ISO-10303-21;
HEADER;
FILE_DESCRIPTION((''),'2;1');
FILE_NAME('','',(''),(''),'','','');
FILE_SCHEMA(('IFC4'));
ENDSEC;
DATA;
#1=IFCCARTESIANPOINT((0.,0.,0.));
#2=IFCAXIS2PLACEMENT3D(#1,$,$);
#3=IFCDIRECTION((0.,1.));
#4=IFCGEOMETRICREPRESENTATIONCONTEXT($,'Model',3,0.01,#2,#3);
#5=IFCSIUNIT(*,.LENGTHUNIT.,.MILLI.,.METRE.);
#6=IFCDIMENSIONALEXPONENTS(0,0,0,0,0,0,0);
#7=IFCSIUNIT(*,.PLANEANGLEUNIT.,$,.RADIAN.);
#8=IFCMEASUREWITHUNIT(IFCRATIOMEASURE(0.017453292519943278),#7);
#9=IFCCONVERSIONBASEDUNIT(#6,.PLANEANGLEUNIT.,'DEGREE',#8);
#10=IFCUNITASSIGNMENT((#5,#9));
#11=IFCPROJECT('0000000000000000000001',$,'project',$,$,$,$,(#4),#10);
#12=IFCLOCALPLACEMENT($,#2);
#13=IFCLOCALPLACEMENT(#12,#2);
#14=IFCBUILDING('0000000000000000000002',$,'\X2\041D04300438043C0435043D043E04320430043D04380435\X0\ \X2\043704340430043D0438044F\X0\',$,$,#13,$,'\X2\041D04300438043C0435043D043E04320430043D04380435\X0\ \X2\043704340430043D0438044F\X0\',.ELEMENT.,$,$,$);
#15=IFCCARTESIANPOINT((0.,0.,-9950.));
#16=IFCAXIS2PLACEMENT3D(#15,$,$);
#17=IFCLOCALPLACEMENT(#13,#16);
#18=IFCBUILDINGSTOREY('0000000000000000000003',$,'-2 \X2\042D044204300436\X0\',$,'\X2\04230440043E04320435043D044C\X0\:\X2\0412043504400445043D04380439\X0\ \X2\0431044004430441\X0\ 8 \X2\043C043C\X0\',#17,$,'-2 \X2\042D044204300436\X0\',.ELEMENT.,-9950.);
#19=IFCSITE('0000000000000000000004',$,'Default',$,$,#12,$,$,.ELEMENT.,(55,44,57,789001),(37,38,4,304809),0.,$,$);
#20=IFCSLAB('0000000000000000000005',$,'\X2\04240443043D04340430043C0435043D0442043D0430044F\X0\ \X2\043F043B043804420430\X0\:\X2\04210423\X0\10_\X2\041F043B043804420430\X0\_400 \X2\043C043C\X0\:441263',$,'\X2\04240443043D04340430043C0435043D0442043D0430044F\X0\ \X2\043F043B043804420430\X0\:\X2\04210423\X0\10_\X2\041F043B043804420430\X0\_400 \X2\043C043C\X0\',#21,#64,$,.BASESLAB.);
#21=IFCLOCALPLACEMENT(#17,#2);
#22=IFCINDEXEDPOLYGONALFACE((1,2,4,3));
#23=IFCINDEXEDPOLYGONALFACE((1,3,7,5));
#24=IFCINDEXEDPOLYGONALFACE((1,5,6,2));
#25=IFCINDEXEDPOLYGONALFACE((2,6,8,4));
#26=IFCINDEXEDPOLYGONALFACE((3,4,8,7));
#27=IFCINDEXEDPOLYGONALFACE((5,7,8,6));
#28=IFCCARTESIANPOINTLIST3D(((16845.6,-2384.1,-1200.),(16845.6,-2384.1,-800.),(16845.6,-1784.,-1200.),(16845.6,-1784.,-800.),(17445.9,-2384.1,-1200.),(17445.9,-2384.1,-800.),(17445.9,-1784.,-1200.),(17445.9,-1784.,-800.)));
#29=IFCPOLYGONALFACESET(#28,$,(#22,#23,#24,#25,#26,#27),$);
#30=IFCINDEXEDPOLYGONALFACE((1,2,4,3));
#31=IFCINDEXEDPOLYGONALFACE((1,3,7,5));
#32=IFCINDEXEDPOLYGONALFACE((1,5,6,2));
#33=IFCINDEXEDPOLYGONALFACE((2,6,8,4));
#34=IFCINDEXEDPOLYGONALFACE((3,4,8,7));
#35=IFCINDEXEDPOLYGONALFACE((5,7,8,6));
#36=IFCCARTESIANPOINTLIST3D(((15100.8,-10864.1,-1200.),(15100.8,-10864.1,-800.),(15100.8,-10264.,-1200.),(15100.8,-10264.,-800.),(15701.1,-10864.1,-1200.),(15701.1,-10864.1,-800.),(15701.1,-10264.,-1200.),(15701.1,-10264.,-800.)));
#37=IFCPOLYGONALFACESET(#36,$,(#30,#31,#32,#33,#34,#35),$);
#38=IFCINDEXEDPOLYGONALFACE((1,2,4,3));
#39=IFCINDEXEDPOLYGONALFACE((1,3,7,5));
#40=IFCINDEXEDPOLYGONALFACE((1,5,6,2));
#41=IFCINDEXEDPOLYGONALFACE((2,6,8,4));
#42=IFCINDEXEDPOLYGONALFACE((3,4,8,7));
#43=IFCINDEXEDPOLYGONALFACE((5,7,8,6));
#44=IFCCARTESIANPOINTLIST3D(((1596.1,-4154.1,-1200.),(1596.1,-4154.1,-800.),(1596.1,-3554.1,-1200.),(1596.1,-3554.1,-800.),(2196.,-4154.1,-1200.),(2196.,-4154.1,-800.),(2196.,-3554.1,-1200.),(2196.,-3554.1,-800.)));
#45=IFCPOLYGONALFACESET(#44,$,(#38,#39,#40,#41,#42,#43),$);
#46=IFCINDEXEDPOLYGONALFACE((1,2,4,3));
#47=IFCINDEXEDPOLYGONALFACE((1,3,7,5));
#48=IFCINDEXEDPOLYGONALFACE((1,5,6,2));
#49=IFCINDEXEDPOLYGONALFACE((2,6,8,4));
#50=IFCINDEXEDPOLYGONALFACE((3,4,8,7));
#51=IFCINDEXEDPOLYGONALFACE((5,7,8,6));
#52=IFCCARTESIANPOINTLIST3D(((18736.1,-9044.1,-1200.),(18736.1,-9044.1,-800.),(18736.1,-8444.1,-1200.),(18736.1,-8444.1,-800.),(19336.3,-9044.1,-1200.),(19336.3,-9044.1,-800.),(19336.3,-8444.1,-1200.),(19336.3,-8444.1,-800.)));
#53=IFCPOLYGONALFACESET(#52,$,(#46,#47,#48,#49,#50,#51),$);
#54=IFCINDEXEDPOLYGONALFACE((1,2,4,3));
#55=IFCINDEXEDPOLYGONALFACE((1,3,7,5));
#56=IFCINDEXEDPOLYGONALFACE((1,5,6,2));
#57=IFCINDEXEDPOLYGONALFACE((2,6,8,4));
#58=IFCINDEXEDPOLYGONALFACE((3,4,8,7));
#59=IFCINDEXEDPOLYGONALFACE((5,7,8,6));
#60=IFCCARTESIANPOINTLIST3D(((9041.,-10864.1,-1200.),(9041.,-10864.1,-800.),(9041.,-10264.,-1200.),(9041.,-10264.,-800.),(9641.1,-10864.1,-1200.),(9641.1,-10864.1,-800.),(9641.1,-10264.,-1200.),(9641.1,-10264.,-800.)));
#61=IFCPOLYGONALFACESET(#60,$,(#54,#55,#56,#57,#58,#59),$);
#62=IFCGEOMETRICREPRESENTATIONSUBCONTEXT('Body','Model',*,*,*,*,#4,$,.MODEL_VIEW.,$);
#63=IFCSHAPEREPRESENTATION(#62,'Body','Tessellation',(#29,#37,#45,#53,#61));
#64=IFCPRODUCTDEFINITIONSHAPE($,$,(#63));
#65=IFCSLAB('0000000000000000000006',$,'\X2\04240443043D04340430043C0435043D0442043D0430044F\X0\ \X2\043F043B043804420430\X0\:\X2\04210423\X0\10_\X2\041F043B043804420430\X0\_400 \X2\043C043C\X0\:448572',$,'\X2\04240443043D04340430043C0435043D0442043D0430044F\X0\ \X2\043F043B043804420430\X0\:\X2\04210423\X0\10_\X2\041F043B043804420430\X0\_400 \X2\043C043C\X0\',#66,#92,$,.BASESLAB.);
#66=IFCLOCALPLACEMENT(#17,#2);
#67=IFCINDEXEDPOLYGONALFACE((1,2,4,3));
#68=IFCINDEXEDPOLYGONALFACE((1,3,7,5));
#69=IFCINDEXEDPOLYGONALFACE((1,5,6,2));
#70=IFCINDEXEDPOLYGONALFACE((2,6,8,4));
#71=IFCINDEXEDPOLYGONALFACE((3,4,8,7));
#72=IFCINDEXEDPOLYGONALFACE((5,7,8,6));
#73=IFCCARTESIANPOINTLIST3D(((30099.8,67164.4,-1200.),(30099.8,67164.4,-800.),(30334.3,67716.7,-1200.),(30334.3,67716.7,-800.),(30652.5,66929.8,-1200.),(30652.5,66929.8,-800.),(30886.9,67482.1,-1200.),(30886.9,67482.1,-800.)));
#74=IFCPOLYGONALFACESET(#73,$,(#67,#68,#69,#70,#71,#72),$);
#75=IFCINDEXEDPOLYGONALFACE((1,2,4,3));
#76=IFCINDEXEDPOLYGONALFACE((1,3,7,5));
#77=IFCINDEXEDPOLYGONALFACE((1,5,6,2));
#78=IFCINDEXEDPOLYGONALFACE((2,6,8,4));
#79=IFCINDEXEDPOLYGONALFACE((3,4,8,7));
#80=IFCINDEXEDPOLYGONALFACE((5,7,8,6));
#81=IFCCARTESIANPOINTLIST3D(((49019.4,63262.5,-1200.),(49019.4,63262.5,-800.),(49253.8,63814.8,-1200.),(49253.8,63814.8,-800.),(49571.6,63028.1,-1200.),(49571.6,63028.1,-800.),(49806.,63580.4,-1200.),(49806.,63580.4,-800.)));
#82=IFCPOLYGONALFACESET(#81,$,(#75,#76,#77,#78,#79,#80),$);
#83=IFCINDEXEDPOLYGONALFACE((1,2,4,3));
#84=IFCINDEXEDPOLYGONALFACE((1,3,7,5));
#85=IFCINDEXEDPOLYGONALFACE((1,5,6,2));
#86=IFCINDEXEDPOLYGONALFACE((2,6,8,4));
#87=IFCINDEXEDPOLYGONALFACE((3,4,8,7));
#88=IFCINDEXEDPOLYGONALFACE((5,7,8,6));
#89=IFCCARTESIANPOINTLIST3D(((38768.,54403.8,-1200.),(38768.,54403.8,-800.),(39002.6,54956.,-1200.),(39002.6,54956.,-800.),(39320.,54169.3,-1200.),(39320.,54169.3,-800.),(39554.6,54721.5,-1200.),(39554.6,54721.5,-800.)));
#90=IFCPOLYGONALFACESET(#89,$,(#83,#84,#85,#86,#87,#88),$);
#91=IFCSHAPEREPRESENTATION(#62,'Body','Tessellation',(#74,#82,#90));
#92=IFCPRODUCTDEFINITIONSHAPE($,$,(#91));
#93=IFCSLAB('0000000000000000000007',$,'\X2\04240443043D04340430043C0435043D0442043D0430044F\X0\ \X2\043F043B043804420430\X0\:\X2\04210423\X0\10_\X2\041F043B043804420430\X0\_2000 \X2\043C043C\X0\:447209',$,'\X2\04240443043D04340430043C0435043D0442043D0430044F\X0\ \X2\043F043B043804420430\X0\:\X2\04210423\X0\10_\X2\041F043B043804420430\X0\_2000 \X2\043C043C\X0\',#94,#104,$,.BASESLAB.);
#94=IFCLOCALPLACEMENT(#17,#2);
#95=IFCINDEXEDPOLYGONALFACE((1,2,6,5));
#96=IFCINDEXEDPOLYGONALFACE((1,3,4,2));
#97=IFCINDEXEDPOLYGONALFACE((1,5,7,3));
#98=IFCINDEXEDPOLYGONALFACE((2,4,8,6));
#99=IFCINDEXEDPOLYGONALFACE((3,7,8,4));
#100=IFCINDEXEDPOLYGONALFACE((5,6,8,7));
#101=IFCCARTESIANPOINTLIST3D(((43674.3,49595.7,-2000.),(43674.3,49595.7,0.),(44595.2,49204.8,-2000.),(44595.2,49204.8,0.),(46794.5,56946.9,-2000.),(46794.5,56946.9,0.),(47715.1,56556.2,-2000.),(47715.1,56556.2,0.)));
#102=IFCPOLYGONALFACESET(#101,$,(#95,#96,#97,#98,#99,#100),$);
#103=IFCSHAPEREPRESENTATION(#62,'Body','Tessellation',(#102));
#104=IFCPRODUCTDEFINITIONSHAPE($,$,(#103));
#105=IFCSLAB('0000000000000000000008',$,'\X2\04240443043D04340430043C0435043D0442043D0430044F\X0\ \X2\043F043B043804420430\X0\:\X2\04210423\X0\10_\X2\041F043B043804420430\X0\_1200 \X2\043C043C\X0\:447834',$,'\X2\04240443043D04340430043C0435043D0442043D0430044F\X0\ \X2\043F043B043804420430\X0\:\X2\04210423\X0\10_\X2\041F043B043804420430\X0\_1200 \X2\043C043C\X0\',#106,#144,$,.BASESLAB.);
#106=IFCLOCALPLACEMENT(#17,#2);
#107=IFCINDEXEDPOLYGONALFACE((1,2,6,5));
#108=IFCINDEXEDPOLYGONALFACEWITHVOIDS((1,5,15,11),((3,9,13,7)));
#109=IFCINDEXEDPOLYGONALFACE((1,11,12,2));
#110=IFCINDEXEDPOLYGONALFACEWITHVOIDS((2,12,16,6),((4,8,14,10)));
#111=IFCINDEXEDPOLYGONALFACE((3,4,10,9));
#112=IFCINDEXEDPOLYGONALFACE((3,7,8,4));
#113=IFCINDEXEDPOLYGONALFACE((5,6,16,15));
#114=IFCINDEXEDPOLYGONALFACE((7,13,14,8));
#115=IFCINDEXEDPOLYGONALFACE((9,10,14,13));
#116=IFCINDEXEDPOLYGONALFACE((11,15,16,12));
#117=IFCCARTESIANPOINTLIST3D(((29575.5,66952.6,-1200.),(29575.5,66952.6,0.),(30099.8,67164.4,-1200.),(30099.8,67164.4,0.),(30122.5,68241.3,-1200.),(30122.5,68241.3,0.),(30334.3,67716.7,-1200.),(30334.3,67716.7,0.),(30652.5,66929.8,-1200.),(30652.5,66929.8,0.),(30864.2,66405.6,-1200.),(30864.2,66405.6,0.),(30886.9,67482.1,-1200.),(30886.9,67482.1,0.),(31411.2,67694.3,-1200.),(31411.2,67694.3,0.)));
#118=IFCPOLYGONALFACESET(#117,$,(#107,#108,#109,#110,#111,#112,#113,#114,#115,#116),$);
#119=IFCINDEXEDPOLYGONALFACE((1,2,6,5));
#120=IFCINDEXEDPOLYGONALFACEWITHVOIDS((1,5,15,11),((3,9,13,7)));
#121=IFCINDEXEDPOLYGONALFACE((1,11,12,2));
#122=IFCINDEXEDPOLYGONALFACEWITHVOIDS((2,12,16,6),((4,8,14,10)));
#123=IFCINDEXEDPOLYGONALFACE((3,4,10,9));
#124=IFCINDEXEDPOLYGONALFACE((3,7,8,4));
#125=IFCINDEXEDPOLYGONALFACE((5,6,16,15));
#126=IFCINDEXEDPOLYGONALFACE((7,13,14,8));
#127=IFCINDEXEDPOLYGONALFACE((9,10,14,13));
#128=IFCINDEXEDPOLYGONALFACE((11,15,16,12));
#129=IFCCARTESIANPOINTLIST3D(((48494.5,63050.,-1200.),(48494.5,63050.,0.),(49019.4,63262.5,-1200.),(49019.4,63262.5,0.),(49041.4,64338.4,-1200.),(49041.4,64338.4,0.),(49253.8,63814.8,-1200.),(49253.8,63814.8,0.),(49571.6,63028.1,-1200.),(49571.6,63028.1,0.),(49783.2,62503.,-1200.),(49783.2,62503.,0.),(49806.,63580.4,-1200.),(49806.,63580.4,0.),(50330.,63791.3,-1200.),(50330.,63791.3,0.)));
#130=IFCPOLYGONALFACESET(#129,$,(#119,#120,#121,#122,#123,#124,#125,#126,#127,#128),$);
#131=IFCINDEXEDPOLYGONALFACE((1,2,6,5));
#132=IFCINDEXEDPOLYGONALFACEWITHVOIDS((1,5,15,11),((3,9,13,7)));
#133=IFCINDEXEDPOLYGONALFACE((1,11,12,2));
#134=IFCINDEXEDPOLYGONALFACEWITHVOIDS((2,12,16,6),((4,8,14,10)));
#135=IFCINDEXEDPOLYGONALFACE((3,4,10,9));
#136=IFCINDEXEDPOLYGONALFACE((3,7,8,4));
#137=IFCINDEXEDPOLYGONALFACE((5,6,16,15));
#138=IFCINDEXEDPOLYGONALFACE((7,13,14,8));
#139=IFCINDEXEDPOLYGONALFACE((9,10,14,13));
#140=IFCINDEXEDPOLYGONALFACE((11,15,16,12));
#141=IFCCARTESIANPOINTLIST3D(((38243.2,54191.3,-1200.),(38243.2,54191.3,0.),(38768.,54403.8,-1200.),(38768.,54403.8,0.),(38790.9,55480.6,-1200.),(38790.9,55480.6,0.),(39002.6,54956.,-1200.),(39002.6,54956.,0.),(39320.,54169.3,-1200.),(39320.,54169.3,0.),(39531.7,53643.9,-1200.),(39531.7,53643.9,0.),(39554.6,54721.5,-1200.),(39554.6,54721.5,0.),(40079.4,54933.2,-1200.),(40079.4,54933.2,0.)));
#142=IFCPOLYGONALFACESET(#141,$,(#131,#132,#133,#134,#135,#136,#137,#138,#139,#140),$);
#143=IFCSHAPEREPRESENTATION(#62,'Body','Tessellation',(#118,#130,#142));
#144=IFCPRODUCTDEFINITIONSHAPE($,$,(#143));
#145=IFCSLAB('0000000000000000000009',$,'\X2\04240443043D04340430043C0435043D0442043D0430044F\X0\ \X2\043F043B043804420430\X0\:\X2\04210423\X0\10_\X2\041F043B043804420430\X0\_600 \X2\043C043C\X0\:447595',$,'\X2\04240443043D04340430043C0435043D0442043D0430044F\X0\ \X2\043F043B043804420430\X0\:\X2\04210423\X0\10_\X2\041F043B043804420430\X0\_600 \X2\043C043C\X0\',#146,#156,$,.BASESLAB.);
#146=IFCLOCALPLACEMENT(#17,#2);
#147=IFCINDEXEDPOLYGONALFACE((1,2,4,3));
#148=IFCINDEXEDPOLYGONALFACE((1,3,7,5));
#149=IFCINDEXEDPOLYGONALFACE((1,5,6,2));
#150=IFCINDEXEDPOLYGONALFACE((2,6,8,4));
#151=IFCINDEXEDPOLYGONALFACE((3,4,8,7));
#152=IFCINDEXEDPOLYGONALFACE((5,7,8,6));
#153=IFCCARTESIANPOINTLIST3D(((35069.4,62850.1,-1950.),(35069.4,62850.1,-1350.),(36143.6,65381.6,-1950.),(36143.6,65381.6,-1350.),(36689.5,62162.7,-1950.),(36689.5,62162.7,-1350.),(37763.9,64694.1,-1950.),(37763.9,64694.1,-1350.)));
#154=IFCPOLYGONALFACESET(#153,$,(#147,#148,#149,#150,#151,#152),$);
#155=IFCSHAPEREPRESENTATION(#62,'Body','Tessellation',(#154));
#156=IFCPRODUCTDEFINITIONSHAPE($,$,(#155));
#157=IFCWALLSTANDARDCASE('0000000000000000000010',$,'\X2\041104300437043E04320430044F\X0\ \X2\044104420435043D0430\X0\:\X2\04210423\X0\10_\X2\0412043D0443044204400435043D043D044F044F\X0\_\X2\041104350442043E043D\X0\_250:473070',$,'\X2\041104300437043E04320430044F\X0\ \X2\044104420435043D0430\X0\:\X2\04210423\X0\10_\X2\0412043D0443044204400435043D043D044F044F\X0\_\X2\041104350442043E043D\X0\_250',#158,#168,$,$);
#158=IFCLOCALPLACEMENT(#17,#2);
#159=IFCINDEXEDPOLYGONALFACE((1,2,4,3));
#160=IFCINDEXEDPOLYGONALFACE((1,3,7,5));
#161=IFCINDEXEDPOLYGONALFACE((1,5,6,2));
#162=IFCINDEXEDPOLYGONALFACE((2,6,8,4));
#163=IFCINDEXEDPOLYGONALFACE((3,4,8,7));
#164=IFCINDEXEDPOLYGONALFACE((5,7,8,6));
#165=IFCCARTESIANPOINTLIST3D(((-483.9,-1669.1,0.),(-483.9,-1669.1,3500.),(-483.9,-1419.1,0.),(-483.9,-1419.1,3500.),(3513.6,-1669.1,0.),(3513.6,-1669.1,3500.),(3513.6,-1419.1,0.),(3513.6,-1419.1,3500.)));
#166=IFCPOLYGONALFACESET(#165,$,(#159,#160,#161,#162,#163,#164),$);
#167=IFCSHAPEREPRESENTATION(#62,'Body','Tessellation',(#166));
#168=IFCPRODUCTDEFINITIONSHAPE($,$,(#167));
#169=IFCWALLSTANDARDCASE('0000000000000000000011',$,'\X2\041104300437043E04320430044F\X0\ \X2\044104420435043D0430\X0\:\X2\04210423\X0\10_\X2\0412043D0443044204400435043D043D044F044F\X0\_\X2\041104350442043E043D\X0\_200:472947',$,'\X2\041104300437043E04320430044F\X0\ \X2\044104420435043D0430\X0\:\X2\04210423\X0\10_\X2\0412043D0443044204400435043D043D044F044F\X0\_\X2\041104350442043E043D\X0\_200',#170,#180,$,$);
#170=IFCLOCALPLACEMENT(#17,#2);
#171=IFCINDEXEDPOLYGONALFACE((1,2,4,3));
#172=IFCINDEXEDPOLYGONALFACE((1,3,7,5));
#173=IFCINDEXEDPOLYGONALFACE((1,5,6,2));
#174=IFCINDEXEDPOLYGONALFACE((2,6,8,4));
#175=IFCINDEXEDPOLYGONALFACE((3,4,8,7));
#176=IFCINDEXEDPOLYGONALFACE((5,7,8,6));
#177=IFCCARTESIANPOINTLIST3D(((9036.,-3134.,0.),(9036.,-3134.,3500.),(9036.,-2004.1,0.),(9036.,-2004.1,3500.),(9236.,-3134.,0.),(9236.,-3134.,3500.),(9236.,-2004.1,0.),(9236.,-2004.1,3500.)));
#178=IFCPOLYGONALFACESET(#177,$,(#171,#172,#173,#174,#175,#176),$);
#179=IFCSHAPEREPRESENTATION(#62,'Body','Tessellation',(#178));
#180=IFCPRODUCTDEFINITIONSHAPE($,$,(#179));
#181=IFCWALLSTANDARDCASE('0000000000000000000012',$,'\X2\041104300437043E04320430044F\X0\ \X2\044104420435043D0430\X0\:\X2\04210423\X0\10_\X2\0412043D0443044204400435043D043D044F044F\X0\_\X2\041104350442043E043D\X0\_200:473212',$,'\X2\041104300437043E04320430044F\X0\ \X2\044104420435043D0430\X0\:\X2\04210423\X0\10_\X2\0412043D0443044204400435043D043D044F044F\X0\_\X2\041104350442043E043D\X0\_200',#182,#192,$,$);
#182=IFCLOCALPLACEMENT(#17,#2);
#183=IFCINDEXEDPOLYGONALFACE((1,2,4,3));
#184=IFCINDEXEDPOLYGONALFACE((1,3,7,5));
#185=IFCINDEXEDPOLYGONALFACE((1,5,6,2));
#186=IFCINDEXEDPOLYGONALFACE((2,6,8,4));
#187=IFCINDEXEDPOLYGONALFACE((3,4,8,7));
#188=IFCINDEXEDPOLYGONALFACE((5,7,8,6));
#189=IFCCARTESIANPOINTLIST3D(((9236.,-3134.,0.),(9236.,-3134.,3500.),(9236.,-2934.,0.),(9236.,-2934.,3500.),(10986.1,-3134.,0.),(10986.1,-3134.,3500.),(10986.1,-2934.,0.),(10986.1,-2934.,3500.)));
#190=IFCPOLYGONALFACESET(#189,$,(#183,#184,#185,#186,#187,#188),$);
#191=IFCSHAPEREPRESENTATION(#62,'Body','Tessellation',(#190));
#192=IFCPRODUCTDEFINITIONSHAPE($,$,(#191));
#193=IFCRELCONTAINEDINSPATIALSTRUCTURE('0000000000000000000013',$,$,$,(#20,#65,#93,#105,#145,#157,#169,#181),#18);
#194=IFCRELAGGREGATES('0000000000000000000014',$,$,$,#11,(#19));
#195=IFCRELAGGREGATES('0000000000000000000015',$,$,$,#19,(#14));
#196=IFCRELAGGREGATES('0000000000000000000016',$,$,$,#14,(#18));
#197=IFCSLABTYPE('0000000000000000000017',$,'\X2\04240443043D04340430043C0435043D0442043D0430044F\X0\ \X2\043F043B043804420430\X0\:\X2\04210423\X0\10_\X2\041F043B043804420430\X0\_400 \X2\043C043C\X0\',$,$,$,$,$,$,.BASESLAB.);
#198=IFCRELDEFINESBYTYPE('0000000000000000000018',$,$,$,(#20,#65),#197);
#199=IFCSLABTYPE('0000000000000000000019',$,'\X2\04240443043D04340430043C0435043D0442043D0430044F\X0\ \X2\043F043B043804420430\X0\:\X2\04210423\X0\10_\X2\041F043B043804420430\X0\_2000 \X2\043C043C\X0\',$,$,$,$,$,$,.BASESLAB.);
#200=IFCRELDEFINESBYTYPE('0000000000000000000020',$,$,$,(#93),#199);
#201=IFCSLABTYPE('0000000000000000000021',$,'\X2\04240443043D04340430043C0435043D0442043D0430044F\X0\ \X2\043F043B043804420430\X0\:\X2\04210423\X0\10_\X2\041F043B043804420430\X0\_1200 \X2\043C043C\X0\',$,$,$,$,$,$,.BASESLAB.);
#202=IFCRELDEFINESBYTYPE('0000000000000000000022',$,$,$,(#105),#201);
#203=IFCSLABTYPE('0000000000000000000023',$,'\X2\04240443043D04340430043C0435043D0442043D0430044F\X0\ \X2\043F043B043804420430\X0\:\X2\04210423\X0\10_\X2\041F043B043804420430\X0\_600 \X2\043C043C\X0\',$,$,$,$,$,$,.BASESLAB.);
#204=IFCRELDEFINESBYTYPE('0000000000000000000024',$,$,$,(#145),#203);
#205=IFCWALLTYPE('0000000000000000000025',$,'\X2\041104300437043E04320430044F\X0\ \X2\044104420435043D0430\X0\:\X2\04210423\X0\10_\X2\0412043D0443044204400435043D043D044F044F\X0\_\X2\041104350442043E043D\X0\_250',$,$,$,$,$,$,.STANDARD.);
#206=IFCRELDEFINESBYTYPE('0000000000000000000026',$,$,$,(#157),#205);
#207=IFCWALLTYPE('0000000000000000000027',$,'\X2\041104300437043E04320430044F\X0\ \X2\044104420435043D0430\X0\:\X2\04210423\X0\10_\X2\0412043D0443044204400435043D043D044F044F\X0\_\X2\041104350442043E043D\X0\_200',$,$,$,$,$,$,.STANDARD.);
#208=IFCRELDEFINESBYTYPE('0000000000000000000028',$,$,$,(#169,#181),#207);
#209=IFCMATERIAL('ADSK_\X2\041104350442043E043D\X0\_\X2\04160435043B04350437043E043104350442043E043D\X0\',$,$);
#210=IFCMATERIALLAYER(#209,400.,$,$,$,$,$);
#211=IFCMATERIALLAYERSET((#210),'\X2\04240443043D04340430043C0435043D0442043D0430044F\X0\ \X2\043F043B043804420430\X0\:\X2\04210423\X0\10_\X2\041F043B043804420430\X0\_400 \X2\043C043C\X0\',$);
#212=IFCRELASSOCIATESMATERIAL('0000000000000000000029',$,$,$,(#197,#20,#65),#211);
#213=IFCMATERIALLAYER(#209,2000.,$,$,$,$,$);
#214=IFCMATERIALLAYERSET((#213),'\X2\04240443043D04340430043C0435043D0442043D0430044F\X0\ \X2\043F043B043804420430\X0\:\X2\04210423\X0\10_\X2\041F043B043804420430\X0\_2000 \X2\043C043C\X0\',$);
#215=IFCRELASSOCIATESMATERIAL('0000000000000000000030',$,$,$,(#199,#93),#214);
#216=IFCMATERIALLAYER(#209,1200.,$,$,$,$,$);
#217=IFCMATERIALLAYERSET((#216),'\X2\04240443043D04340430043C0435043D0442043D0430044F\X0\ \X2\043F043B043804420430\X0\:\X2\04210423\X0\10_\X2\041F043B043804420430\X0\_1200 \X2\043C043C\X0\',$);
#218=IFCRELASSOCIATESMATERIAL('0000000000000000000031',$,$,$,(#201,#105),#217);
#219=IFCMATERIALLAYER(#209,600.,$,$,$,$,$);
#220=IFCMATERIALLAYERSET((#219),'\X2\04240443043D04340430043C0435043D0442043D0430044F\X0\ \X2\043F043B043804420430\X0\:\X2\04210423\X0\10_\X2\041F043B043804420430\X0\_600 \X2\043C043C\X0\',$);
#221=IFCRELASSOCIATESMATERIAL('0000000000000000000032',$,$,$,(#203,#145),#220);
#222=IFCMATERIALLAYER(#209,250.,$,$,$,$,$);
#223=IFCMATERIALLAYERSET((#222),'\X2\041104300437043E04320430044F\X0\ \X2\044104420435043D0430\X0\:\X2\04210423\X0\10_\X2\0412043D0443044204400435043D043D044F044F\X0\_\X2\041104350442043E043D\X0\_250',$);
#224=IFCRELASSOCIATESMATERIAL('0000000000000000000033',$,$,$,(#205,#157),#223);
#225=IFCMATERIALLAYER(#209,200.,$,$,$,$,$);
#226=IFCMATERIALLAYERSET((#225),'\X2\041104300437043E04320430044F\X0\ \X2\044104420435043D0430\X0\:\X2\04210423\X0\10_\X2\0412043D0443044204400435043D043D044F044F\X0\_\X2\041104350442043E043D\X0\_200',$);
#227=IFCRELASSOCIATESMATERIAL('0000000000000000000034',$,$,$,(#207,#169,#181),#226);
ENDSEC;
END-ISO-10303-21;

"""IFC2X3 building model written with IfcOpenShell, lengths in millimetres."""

from ifc_helpers import new_model, entity, si_unit, converted_unit, direction, frame, frame_2d, origin, origin_2d_with_axis, place, context, subcontext, project, spatial, polyline, rectangle, outline, extrude, material, layer, layer_set, layer_usage, type_object, element, save


model = new_model("IFC2X3")

# Units and contexts
model_context = context("Model", 3, precision=0.01, world=origin(), true_north=direction((0.0, 1.0)))
body_context = subcontext(model_context, "Body", "Model", "MODEL_VIEW")
ifc_project = project(units=[si_unit("LENGTHUNIT", "METRE", prefix="MILLI"), converted_unit("PLANEANGLEUNIT", "DEGREE", entity("IfcRatioMeasure", 0.017453292519943278), si_unit("PLANEANGLEUNIT", "RADIAN"), dimensions=[0, 0, 0, 0, 0, 0, 0])], contexts=[model_context])

# Site, building, storey
site_placement = place(None, origin())
site = spatial("IfcSite", under=ifc_project, at=site_placement, Name="Default", CompositionType="ELEMENT", RefLatitude=(55, 44, 57, 789001), RefLongitude=(37, 38, 4, 304809), RefElevation=0.0)
building_placement = place(site_placement, origin())
building = spatial("IfcBuilding", under=site, at=building_placement, Name="Наименование здания", LongName="Наименование здания", CompositionType="ELEMENT")
storey_placement = place(building_placement, frame((0.0, 0.0, -9950.0)))
storey = spatial("IfcBuildingStorey", under=building, at=storey_placement, Name="-2 Этаж", ObjectType="Уровень:Верхний брус 8 мм", LongName="-2 Этаж", CompositionType="ELEMENT", Elevation=-9950.0)

# Slabs
ifc_material_1 = material(Name="ADSK_Бетон_Железобетон")
ifc_layer_1 = layer(ifc_material_1, 400.0)
ifc_layer_set_1 = layer_set([ifc_layer_1], Name="Фундаментная плита:СУ10_Плита_400 мм")
ifc_layer_usage_1 = layer_usage(ifc_layer_set_1, "AXIS3", "POSITIVE", 0.0)
slab_type_1 = type_object("IfcSlabType", Name="Фундаментная плита:СУ10_Плита_400 мм", PredefinedType="BASESLAB", material=ifc_layer_set_1)
slab_1_placement = place(storey_placement, origin())
element("IfcSlab", 1, at=slab_1_placement, inside=storey, type_object=slab_type_1, material=ifc_layer_usage_1, Name="Фундаментная плита:СУ10_Плита_400 мм:441263", ObjectType="Фундаментная плита:СУ10_Плита_400 мм", PredefinedType="BASESLAB", context=body_context, shape_type="SweptSolid", body=[
    extrude(rectangle(XDim=600.2, YDim=600.1, at=origin_2d_with_axis()), frame((17145.8, -2084.1, -1200.0), z_axis=(0.0, 0.0, 1.0), x_axis=(-1.0, 0.0, 0.0)), (0.0, 0.0, 1.0), 400.0),
    extrude(rectangle(XDim=600.2, YDim=600.1, at=origin_2d_with_axis()), frame((15400.9, -10564.1, -1200.0), z_axis=(0.0, 0.0, 1.0), x_axis=(-1.0, 0.0, 0.0)), (0.0, 0.0, 1.0), 400.0),
    extrude(rectangle(XDim=600.0, YDim=600.0, at=origin_2d_with_axis()), frame((1896.0, -3854.1, -1200.0), z_axis=(0.0, 0.0, 1.0), x_axis=(-1.0, 0.0, 0.0)), (0.0, 0.0, 1.0), 400.0),
    extrude(rectangle(XDim=600.2, YDim=600.1, at=origin_2d_with_axis()), frame((19036.2, -8744.1, -1200.0), z_axis=(0.0, 0.0, 1.0), x_axis=(-1.0, 0.0, 0.0)), (0.0, 0.0, 1.0), 400.0),
    extrude(rectangle(XDim=600.1, YDim=600.1, at=origin_2d_with_axis()), frame((9341.1, -10564.1, -1200.0), z_axis=(0.0, 0.0, 1.0), x_axis=(-1.0, 0.0, 0.0)), (0.0, 0.0, 1.0), 400.0),
])
slab_2_placement = place(storey_placement, origin())
element("IfcSlab", 2, at=slab_2_placement, inside=storey, type_object=slab_type_1, material=ifc_layer_usage_1, Name="Фундаментная плита:СУ10_Плита_400 мм:448572", ObjectType="Фундаментная плита:СУ10_Плита_400 мм", PredefinedType="BASESLAB", context=body_context, shape_type="SweptSolid", body=[
    extrude(rectangle(XDim=600.0, YDim=600.4, at=frame_2d((0.0, 0.0), x_axis=(1.0, 0.0))), frame((30493.4, 67323.2, -1200.0), z_axis=(0.0, 0.0, 1.0), x_axis=(-0.390705, -0.920516, 0.0)), (0.0, 0.0, 1.0), 400.0),
    extrude(outline(polyline([(-300.0, -300.0), (300.0, -300.0), (300.0, 299.9), (-300.0, 300.0), (-300.0, -300.0)])), frame((49412.7, 63421.4, -1200.0), z_axis=(0.0, 0.0, 1.0), x_axis=(-0.390716, -0.920511, 0.0)), (0.0, 0.0, 1.0), 400.0),
    extrude(rectangle(XDim=600.0, YDim=599.7, at=origin_2d_with_axis()), frame((39161.3, 54562.6, -1200.0), z_axis=(0.0, 0.0, 1.0), x_axis=(-0.391001, -0.92039, 0.0)), (0.0, 0.0, 1.0), 400.0),
])
ifc_layer_2 = layer(ifc_material_1, 2000.0)
ifc_layer_set_2 = layer_set([ifc_layer_2], Name="Фундаментная плита:СУ10_Плита_2000 мм")
ifc_layer_usage_2 = layer_usage(ifc_layer_set_2, "AXIS3", "POSITIVE", 0.0)
slab_type_2 = type_object("IfcSlabType", Name="Фундаментная плита:СУ10_Плита_2000 мм", PredefinedType="BASESLAB", material=ifc_layer_set_2)
slab_3_placement = place(storey_placement, origin())
element("IfcSlab", 3, at=slab_3_placement, inside=storey, type_object=slab_type_2, material=ifc_layer_usage_2, Name="Фундаментная плита:СУ10_Плита_2000 мм:447209", ObjectType="Фундаментная плита:СУ10_Плита_2000 мм", PredefinedType="BASESLAB", context=body_context, shape_type="SweptSolid", body=[
    extrude(outline(polyline([(-500.1, -3993.0), (499.9, -3993.0), (500.3, 3993.0), (-500.1, 3993.0), (-500.1, -3993.0)])), frame((45694.8, 53075.9, 0.0), z_axis=(0.0, 0.0, -1.0), x_axis=(0.92051, -0.390719, 0.0)), (0.0, 0.0, 1.0), 2000.0),
])
ifc_layer_3 = layer(ifc_material_1, 1200.0)
ifc_layer_set_3 = layer_set([ifc_layer_3], Name="Фундаментная плита:СУ10_Плита_1200 мм")
ifc_layer_usage_3 = layer_usage(ifc_layer_set_3, "AXIS3", "POSITIVE", 0.0)
slab_type_3 = type_object("IfcSlabType", Name="Фундаментная плита:СУ10_Плита_1200 мм", PredefinedType="BASESLAB", material=ifc_layer_set_3)
slab_4_placement = place(storey_placement, origin())
element("IfcSlab", 4, at=slab_4_placement, inside=storey, type_object=slab_type_3, material=ifc_layer_usage_3, Name="Фундаментная плита:СУ10_Плита_1200 мм:447834", ObjectType="Фундаментная плита:СУ10_Плита_1200 мм", PredefinedType="BASESLAB", context=body_context, shape_type="SweptSolid", body=[
    extrude(outline(polyline([(-700.0, -700.0), (700.0, -700.0), (700.0, 700.0), (-700.0, 700.0), (-700.0, -700.0)]), holes=[polyline([(-299.8, -300.1), (-299.8, 300.3), (300.2, 300.3), (300.2, -300.1), (-299.8, -300.1)])]), frame((30493.3, 67323.5, -1200.0), z_axis=(0.0, 0.0, 1.0), x_axis=(-0.390705, -0.920516, 0.0)), (0.0, 0.0, 1.0), 1200.0),
    extrude(outline(polyline([(-699.8, -700.0), (699.8, -700.0), (699.8, 700.0), (-699.8, 700.0), (-699.8, -700.0)]), holes=[polyline([(-300.9, -299.9), (-300.9, 300.1), (299.1, 300.0), (299.1, -299.9), (-300.9, -299.9)])]), frame((49412.3, 63420.6, -1200.0), z_axis=(0.0, 0.0, 1.0), x_axis=(-0.390716, -0.920511, 0.0)), (0.0, 0.0, 1.0), 1200.0),
    extrude(outline(polyline([(-700.4, -700.0), (700.4, -700.0), (700.4, 700.0), (-700.4, 700.0), (-700.4, -700.0)]), holes=[polyline([(-300.4, -300.0), (-300.4, 299.8), (299.6, 299.8), (299.6, -300.0), (-300.4, -300.0)])]), frame((39161.3, 54562.2, -1200.0), z_axis=(0.0, 0.0, 1.0), x_axis=(-0.391001, -0.92039, 0.0)), (0.0, 0.0, 1.0), 1200.0),
])
ifc_layer_4 = layer(ifc_material_1, 600.0)
ifc_layer_set_4 = layer_set([ifc_layer_4], Name="Фундаментная плита:СУ10_Плита_600 мм")
ifc_layer_usage_4 = layer_usage(ifc_layer_set_4, "AXIS3", "POSITIVE", 0.0)
slab_type_4 = type_object("IfcSlabType", Name="Фундаментная плита:СУ10_Плита_600 мм", PredefinedType="BASESLAB", material=ifc_layer_set_4)
slab_5_placement = place(storey_placement, origin())
element("IfcSlab", 5, at=slab_5_placement, inside=storey, type_object=slab_type_4, material=ifc_layer_usage_4, Name="Фундаментная плита:СУ10_Плита_600 мм:447595", ObjectType="Фундаментная плита:СУ10_Плита_600 мм", PredefinedType="BASESLAB", context=body_context, shape_type="SweptSolid", body=[
    extrude(outline(polyline([(-880.0, -1375.0), (880.1, -1375.0), (879.9, 1375.0), (-880.0, 1375.0), (-880.0, -1375.0)])), frame((36416.6, 63772.1, -1350.0), z_axis=(0.0, 0.0, -1.0), x_axis=(0.920551, -0.390623, 0.0)), (0.0, 0.0, 1.0), 600.0),
])

# Walls
ifc_layer_5 = layer(ifc_material_1, 250.0)
ifc_layer_set_5 = layer_set([ifc_layer_5], Name="Базовая стена:СУ10_Внутренняя_Бетон_250")
ifc_layer_usage_5 = layer_usage(ifc_layer_set_5, "AXIS2", "NEGATIVE", 125.0)
wall_type_1 = type_object("IfcWallType", Name="Базовая стена:СУ10_Внутренняя_Бетон_250", PredefinedType="STANDARD", material=ifc_layer_set_5)
wall_1_placement = place(storey_placement, frame((3513.6, -1544.1, 0.0), z_axis=(0.0, 0.0, 1.0), x_axis=(-1.0, 0.0, 0.0)))
element("IfcWallStandardCase", 6, at=wall_1_placement, inside=storey, type_object=wall_type_1, material=ifc_layer_usage_5, Name="Базовая стена:СУ10_Внутренняя_Бетон_250:473070", ObjectType="Базовая стена:СУ10_Внутренняя_Бетон_250", context=body_context, shape_type="SweptSolid", body=[
    extrude(rectangle(XDim=3997.5, YDim=250.0, at=frame_2d((1998.7, 0.0), x_axis=(-1.0, 0.0))), origin(), (0.0, 0.0, 1.0), 3500.0),
])
ifc_layer_6 = layer(ifc_material_1, 200.0)
ifc_layer_set_6 = layer_set([ifc_layer_6], Name="Базовая стена:СУ10_Внутренняя_Бетон_200")
ifc_layer_usage_6 = layer_usage(ifc_layer_set_6, "AXIS2", "NEGATIVE", 100.0)
wall_type_2 = type_object("IfcWallType", Name="Базовая стена:СУ10_Внутренняя_Бетон_200", PredefinedType="STANDARD", material=ifc_layer_set_6)
wall_2_placement = place(storey_placement, frame((9136.0, -2004.1, 0.0), z_axis=(0.0, 0.0, 1.0), x_axis=(0.0, -1.0, 0.0)))
element("IfcWallStandardCase", 7, at=wall_2_placement, inside=storey, type_object=wall_type_2, material=ifc_layer_usage_6, Name="Базовая стена:СУ10_Внутренняя_Бетон_200:472947", ObjectType="Базовая стена:СУ10_Внутренняя_Бетон_200", context=body_context, shape_type="SweptSolid", body=[
    extrude(rectangle(XDim=1130.0, YDim=200.0, at=frame_2d((565.0, 0.0), x_axis=(-1.0, 0.0))), origin(), (0.0, 0.0, 1.0), 3500.0),
])
wall_3_placement = place(storey_placement, frame((10986.1, -3034.0, 0.0), z_axis=(0.0, 0.0, 1.0), x_axis=(-1.0, 0.0, 0.0)))
element("IfcWallStandardCase", 8, at=wall_3_placement, inside=storey, type_object=wall_type_2, material=ifc_layer_usage_6, Name="Базовая стена:СУ10_Внутренняя_Бетон_200:473212", ObjectType="Базовая стена:СУ10_Внутренняя_Бетон_200", context=body_context, shape_type="SweptSolid", body=[
    extrude(rectangle(XDim=1750.1, YDim=200.0, at=frame_2d((875.0, 0.0), x_axis=(-1.0, 0.0))), origin(), (0.0, 0.0, 1.0), 3500.0),
])

save(model, "model.ifc")
